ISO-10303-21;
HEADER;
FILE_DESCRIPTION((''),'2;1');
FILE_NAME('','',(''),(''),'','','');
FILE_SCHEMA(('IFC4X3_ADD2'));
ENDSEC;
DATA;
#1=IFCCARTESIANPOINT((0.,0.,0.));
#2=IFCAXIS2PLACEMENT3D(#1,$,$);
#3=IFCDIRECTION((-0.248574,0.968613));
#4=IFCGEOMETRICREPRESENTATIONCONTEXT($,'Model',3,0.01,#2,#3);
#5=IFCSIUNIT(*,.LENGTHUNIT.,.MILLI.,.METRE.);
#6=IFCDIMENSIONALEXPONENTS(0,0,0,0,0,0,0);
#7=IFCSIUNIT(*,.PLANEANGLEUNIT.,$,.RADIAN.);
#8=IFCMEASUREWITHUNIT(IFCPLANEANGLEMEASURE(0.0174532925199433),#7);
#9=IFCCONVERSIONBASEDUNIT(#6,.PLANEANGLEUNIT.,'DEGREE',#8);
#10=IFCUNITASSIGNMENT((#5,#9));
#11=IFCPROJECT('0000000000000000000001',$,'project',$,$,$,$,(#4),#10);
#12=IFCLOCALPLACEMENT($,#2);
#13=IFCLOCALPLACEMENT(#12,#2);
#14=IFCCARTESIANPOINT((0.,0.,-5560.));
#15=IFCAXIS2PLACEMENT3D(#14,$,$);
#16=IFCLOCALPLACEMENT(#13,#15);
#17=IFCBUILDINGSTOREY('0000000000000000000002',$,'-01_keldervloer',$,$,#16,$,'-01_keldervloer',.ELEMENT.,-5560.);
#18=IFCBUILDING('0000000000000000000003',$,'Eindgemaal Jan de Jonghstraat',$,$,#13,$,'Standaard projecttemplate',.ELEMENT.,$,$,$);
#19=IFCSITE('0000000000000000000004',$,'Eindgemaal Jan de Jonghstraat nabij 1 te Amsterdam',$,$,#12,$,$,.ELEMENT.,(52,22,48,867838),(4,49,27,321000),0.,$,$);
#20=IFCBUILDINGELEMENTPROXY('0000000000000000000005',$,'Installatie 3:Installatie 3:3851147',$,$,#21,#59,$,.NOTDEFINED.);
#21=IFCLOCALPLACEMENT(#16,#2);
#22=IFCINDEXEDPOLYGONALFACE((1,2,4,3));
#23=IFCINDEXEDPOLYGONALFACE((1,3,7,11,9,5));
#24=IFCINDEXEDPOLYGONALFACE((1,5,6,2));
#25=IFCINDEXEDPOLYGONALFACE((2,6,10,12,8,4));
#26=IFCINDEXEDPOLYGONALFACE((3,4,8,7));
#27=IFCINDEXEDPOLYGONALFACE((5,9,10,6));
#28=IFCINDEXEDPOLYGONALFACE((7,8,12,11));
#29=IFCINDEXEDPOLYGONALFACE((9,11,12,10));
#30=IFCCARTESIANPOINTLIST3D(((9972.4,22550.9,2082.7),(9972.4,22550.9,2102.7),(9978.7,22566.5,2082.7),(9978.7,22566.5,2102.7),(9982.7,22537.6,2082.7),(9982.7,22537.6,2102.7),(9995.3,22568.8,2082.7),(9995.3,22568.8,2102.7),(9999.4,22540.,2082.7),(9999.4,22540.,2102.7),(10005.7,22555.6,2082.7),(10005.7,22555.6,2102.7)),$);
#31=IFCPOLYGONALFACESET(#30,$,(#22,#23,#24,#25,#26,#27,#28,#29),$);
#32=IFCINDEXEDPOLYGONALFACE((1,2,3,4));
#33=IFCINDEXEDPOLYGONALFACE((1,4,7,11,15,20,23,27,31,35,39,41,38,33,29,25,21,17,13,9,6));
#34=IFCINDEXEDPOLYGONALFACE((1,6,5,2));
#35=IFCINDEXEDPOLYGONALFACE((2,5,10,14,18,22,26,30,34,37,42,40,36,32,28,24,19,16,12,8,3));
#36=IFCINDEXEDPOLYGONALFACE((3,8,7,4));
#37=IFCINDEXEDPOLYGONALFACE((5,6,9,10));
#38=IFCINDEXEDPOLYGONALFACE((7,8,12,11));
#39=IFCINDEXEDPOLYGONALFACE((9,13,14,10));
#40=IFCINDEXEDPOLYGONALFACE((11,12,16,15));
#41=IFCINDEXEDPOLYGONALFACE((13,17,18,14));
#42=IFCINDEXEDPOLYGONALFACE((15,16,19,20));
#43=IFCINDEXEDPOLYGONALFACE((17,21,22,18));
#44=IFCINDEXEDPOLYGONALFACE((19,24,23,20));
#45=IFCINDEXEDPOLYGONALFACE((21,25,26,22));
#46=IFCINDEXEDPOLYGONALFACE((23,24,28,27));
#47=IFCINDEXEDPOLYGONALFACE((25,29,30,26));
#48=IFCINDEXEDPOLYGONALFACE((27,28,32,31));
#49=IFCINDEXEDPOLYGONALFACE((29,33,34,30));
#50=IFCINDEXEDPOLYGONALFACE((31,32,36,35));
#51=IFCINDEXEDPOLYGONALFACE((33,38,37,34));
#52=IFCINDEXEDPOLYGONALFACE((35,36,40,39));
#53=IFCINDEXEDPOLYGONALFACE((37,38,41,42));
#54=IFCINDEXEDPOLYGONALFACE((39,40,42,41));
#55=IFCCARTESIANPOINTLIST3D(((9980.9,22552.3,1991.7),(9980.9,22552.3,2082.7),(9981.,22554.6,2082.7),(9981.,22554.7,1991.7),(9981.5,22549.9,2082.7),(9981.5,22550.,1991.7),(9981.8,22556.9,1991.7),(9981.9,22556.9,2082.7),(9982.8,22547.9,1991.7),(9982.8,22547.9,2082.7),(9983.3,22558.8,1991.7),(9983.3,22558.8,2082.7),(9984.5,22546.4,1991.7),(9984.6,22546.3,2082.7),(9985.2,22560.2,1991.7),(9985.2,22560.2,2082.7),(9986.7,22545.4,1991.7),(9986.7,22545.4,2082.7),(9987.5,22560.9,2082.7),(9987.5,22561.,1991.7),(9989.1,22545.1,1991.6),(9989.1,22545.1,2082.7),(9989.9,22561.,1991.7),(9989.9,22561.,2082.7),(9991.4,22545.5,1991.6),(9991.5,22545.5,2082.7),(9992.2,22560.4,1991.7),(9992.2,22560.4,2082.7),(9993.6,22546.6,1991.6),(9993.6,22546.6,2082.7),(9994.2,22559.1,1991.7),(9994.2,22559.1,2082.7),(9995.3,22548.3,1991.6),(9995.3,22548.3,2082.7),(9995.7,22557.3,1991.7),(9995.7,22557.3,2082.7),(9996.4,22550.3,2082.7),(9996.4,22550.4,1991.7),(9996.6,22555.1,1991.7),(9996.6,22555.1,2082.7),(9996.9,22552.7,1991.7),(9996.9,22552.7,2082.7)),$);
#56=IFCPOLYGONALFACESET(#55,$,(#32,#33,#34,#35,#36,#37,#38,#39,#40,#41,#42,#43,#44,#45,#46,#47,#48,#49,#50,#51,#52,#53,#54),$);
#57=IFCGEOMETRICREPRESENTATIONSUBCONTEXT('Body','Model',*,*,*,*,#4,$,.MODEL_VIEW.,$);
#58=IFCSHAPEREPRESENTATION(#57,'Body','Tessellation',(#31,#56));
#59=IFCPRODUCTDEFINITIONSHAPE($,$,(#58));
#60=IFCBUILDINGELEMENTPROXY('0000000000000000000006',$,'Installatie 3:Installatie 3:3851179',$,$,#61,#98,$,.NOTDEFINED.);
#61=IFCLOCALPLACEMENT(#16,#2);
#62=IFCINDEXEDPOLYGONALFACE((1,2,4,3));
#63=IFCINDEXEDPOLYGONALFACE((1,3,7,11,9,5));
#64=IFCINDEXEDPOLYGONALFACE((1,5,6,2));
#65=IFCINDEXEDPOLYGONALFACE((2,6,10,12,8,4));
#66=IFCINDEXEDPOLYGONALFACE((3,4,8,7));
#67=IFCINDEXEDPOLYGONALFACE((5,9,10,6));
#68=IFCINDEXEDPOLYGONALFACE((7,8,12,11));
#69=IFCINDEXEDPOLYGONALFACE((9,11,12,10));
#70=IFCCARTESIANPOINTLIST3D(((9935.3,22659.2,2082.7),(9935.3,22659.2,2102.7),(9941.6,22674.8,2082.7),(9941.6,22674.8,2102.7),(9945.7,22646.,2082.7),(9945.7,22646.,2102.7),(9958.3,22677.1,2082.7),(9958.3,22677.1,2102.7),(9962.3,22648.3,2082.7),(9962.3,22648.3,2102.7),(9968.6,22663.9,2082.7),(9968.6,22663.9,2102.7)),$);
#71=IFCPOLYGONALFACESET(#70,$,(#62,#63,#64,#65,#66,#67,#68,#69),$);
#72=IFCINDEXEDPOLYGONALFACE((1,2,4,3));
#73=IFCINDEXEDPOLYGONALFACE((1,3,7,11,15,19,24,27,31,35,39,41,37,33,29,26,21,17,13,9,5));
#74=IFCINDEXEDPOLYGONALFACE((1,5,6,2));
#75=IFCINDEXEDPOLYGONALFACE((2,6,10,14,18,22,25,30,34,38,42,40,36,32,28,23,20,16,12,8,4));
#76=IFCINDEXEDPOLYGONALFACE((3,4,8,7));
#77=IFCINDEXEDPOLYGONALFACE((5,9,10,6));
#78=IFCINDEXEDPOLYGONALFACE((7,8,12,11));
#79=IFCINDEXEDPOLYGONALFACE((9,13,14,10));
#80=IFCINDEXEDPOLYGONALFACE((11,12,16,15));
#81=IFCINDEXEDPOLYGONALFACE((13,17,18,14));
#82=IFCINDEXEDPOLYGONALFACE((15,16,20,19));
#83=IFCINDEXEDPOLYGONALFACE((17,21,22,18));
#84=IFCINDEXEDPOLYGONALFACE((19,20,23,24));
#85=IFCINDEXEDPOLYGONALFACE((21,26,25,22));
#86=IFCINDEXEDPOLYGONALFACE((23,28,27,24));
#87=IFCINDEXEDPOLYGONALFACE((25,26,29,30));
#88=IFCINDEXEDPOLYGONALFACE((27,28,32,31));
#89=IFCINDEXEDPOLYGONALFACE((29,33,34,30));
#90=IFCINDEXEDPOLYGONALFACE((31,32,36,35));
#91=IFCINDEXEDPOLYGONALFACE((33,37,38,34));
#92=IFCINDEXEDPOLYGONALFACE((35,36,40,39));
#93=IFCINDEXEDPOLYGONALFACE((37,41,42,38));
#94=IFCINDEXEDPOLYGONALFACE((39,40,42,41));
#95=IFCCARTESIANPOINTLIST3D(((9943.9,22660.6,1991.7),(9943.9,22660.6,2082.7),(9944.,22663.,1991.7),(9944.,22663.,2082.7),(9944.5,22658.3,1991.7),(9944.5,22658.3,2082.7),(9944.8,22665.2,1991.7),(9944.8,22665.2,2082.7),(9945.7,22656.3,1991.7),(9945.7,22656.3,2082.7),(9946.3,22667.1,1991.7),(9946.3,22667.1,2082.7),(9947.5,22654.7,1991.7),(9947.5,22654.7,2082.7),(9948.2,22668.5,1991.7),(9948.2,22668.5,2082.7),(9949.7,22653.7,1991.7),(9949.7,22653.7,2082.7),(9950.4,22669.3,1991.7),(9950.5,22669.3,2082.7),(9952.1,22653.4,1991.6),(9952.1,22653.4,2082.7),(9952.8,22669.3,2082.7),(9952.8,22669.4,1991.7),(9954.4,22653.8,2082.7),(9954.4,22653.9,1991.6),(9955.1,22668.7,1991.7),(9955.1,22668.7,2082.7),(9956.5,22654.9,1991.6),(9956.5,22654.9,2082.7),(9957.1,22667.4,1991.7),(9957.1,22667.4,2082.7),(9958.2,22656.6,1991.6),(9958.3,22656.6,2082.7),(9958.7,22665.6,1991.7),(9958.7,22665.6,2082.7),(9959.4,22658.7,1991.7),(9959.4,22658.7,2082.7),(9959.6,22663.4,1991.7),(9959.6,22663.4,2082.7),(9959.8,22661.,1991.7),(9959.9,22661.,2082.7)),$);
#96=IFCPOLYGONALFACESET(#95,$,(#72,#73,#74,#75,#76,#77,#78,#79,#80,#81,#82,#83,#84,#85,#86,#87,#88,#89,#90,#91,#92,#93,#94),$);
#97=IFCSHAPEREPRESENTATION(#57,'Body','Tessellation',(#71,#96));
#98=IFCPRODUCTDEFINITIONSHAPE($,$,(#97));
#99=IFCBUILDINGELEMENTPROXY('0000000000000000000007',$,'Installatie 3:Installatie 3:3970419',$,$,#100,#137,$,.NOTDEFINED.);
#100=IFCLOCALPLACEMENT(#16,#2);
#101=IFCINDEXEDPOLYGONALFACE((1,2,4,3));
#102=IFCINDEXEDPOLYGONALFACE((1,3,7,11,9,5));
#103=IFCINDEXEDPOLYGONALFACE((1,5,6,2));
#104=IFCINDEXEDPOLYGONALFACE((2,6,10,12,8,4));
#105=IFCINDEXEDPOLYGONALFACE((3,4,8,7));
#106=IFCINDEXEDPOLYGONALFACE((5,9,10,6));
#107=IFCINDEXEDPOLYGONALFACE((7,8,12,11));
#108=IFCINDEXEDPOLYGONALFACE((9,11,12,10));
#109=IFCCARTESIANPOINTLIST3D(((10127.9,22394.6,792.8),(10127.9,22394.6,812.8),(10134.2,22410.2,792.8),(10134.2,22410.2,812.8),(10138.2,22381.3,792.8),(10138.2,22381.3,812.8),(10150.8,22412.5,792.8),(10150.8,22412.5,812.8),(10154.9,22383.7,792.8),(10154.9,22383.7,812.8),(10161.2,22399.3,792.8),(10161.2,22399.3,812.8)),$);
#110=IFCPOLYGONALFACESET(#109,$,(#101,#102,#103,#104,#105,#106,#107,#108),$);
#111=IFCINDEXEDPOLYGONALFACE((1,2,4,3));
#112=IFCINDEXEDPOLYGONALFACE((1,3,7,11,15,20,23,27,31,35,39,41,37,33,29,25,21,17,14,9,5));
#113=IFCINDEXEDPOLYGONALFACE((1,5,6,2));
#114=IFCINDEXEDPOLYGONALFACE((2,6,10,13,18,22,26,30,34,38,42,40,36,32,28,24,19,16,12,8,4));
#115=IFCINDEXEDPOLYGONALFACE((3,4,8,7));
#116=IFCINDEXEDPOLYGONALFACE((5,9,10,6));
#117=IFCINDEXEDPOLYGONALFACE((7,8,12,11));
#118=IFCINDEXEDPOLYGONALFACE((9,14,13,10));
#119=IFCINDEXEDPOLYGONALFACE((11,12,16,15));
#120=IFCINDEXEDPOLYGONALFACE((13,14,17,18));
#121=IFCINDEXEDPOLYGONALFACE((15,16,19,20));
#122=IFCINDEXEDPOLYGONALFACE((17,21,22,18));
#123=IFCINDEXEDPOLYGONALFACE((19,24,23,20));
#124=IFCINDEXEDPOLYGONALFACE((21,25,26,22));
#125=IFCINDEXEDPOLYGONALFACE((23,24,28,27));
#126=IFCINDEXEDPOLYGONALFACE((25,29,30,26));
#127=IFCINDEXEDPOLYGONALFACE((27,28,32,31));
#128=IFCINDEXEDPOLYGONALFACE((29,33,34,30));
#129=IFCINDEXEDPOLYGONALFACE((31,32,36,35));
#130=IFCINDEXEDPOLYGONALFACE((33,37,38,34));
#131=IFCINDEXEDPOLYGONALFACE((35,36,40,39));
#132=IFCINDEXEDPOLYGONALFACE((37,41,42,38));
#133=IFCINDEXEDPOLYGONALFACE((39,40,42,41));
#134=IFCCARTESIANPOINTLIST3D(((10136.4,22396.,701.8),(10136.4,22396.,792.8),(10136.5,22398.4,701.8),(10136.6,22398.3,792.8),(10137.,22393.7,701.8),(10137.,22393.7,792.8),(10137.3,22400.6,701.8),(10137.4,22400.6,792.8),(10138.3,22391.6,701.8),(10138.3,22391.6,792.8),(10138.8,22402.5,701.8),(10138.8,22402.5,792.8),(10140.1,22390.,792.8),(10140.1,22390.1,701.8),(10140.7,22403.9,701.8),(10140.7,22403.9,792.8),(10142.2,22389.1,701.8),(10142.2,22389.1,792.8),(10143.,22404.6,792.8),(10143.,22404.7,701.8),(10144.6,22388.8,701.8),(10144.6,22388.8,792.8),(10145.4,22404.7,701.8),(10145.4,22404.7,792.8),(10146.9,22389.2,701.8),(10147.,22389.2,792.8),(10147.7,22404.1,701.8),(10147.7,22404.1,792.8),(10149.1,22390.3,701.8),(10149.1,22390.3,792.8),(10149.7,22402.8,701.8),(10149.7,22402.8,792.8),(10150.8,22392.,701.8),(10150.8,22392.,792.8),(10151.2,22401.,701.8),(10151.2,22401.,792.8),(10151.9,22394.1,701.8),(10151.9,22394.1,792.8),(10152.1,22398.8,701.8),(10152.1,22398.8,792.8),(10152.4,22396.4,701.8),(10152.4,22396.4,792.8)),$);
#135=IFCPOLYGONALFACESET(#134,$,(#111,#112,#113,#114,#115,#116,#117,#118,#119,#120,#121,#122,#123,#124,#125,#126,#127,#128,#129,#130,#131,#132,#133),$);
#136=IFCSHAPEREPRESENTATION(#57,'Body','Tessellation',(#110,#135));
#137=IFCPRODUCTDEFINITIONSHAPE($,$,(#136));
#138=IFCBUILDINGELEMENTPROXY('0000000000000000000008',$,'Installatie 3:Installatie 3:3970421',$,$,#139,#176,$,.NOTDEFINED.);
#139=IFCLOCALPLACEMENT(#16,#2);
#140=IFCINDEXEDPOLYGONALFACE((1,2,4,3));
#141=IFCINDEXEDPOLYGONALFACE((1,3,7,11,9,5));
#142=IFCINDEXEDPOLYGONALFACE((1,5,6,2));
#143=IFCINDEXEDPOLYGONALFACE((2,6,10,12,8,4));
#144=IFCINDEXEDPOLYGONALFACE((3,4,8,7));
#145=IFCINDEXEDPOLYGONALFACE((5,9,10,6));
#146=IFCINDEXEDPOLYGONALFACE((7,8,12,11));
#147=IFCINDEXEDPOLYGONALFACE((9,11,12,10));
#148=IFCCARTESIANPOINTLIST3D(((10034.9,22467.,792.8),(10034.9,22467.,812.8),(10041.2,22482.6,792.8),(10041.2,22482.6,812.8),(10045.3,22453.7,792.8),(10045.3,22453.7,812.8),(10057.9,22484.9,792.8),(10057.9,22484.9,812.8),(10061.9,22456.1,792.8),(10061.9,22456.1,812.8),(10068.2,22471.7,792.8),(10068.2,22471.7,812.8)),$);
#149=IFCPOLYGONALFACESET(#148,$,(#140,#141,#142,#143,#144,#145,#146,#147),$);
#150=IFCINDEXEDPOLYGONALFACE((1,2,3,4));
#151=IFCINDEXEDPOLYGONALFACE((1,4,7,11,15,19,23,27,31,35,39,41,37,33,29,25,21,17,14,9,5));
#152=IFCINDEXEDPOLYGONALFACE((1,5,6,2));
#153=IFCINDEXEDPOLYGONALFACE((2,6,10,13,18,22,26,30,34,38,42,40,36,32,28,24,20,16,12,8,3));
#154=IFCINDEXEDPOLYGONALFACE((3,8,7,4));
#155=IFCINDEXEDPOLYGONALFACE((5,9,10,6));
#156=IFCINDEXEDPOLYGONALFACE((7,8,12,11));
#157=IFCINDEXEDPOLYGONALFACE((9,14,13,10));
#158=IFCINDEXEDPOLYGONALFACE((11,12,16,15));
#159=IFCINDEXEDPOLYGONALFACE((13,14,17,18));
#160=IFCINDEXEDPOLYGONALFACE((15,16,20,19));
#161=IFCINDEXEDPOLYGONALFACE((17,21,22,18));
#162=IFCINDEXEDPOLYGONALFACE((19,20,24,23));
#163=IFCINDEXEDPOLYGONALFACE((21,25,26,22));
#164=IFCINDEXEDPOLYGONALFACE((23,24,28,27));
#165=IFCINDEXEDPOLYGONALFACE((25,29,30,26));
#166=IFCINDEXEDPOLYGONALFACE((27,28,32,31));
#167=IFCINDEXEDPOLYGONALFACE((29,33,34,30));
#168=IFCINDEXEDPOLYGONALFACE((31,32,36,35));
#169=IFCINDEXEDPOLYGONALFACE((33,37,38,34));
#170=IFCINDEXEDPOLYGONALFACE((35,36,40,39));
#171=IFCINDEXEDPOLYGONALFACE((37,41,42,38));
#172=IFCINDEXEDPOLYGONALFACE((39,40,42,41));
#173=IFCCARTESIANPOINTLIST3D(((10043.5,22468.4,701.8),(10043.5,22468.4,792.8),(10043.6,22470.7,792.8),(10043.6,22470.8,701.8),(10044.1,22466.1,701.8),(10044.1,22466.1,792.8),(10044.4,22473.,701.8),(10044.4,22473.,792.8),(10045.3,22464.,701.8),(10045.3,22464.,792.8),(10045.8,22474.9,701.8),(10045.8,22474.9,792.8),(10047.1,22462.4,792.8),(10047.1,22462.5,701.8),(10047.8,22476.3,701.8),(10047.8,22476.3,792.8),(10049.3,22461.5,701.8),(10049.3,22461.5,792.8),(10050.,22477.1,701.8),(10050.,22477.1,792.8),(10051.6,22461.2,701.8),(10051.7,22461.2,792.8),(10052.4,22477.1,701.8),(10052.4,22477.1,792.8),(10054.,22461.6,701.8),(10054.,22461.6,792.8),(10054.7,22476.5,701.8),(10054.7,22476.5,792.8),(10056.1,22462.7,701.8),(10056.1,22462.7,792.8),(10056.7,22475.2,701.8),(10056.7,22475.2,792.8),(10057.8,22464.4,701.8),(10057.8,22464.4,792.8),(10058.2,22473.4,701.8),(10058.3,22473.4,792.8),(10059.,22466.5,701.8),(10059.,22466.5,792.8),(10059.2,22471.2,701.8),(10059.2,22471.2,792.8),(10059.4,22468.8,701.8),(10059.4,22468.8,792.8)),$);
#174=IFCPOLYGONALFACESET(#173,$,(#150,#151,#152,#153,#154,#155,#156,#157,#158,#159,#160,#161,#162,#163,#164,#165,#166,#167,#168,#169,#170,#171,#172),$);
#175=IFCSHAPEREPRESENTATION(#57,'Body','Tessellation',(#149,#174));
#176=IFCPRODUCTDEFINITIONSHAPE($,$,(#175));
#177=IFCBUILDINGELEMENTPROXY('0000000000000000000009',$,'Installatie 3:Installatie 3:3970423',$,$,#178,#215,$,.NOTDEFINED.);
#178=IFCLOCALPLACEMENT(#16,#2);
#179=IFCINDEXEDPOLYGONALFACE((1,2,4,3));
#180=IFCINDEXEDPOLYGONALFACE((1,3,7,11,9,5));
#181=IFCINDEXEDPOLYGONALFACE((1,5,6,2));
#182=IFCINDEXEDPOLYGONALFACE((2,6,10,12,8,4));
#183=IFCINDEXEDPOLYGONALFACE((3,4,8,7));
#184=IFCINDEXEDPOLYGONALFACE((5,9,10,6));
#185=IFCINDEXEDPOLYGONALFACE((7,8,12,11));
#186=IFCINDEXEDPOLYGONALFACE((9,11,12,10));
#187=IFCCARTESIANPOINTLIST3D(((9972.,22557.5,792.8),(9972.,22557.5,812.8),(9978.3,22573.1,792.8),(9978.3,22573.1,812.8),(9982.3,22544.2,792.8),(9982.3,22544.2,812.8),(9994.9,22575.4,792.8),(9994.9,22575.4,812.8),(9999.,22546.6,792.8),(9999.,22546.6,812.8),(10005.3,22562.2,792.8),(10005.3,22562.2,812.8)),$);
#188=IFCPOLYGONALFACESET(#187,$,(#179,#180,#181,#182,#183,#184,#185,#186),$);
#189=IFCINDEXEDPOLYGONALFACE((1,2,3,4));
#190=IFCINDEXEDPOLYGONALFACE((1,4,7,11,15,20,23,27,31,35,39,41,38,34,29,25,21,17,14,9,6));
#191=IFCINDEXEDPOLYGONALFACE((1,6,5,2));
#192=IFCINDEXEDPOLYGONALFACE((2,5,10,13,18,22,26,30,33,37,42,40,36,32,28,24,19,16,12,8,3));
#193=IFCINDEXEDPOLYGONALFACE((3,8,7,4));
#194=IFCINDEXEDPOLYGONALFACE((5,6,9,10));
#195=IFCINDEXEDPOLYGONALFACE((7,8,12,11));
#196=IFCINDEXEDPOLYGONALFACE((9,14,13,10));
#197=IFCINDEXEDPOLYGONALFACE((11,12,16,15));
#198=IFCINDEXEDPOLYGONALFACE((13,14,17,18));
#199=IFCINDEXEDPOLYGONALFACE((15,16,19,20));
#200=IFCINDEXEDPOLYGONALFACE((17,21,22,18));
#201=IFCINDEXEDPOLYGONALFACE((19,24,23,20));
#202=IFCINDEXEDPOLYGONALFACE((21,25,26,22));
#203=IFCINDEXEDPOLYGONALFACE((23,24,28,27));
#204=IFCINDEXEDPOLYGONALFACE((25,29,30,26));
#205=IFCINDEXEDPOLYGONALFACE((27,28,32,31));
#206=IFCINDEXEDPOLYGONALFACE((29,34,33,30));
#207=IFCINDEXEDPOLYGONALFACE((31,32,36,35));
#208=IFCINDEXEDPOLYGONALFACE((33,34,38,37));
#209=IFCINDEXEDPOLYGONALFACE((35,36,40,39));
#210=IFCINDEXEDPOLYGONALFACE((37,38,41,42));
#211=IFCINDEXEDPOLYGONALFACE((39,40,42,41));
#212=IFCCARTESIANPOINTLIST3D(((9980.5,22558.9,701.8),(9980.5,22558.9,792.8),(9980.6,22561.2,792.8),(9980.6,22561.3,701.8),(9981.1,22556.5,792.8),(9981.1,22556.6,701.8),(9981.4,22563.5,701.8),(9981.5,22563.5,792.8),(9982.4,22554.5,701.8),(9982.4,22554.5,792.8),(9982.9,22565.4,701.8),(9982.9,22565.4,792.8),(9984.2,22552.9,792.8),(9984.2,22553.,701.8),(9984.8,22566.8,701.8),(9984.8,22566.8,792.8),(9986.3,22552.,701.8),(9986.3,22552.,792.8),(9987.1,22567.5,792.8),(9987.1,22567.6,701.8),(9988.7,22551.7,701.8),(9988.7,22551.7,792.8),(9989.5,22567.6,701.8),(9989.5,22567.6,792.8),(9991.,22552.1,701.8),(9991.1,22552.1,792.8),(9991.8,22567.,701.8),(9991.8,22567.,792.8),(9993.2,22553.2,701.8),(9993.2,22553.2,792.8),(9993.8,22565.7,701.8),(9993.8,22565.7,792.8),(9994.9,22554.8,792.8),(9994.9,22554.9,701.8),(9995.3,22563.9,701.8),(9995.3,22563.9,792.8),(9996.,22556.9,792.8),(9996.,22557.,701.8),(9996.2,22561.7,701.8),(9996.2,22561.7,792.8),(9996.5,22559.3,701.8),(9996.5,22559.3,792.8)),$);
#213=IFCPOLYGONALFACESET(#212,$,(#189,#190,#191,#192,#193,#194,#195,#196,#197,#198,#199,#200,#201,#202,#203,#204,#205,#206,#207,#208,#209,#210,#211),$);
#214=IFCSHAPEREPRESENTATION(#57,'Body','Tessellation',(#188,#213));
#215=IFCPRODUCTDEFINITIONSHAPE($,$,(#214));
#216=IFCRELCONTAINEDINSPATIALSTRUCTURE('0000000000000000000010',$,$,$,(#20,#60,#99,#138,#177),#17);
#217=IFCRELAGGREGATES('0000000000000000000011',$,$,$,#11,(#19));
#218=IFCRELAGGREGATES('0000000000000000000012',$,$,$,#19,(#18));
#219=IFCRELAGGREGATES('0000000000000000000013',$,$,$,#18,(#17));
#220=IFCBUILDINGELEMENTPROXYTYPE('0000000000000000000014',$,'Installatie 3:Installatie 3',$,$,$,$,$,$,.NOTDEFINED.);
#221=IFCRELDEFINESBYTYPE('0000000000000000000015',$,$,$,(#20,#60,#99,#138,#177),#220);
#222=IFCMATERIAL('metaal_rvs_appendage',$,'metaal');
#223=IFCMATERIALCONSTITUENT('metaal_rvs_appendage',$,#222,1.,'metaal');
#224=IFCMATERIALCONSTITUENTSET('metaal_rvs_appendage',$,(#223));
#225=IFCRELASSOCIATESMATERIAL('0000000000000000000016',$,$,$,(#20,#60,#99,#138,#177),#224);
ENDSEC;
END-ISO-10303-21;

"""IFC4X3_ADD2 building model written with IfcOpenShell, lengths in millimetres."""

from ifc_helpers import new_model, entity, si_unit, converted_unit, direction, frame, frame_2d, origin, place, context, subcontext, project, spatial, polyline, circle, outline, extrude, source, transform, mapped, material, constituent, constituent_set, type_object, type_shapes, element, save


model = new_model("IFC4X3_ADD2")

# Units and contexts
model_context = context("Model", 3, precision=0.01, world=origin(), true_north=direction((-0.248574, 0.968613)))
body_context = subcontext(model_context, "Body", "Model", "MODEL_VIEW")
ifc_project = project(units=[si_unit("LENGTHUNIT", "METRE", prefix="MILLI"), converted_unit("PLANEANGLEUNIT", "DEGREE", entity("IfcPlaneAngleMeasure", 0.0174532925199433), si_unit("PLANEANGLEUNIT", "RADIAN"), dimensions=[0, 0, 0, 0, 0, 0, 0])], contexts=[model_context])

# Site, building, storey
site_placement = place(None, origin())
site = spatial("IfcSite", under=ifc_project, at=site_placement, Name="Eindgemaal Jan de Jonghstraat nabij 1 te Amsterdam", CompositionType="ELEMENT", RefLatitude=(52, 22, 48, 867838), RefLongitude=(4, 49, 27, 321000), RefElevation=0.0)
building_placement = place(site_placement, origin())
building = spatial("IfcBuilding", under=site, at=building_placement, Name="Eindgemaal Jan de Jonghstraat", LongName="Standaard projecttemplate", CompositionType="ELEMENT")
storey_placement = place(building_placement, frame((0.0, 0.0, -5560.0)))
storey = spatial("IfcBuildingStorey", under=building, at=storey_placement, Name="-01_keldervloer", LongName="-01_keldervloer", CompositionType="ELEMENT", Elevation=-5560.0)

# Building element proxies
ifc_material_1 = material(Name="metaal_rvs_appendage", Category="metaal")
ifc_constituent_1 = constituent(ifc_material_1, Name="metaal_rvs_appendage", Category="metaal", fraction=1.0)
ifc_constituent_set_1 = constituent_set(constituents=[ifc_constituent_1], Name="metaal_rvs_appendage")
building_element_proxy_type_1 = type_object("IfcBuildingElementProxyType", Name="Installatie 3:Installatie 3", PredefinedType="NOTDEFINED")
shared_shape_1 = source(origin(), body_context, "Body", "SweptSolid", [
    extrude(outline(polyline([(-8.4, -14.6), (8.4, -14.6), (16.8, 0.0), (8.4, 14.6), (-8.4, 14.6), (-16.8, 0.0), (-8.4, -14.6)])), frame((0.0, 0.0, 41.5), z_axis=(0.0, 0.0, 1.0), x_axis=(-0.400458, 0.916315, 0.0)), (0.0, 0.0, 1.0), 20.0),
    extrude(circle(Radius=8.0, at=frame_2d((0.0, 0.0), x_axis=(1.0, 0.0))), frame((-0.2, -0.1, -49.5), z_axis=(0.000101, -0.000286, 1.0), x_axis=(1.0, 0.0, -0.000101)), (0.0, 0.0, 1.0), 91.1),
])
type_shapes(building_element_proxy_type_1, [shared_shape_1])
for number, where, z_axis, x_axis, name in (
    (1, (9989.0, 22553.2, 2041.2), (0.0, 0.0, 1.0), (0.968613, 0.248574, 0.0), "Installatie 3:Installatie 3:3851147"),
    (2, (9952.0, 22661.6, 2041.2), (0.0, 0.0, 1.0), (0.968613, 0.248574, 0.0), "Installatie 3:Installatie 3:3851179"),
    (3, (10144.5, 22396.9, 751.3), (0.0, 0.0, 1.0), (0.968613, 0.248574, 0.0), "Installatie 3:Installatie 3:3970419"),
    (4, (10051.6, 22469.3, 751.3), (0.0, 0.0, 1.0), (0.968613, 0.248574, 0.0), "Installatie 3:Installatie 3:3970421"),
    (5, (9988.6, 22559.8, 751.3), (0.0, 0.0, 1.0), (0.968613, 0.248574, 0.0), "Installatie 3:Installatie 3:3970423"),
):
    element("IfcBuildingElementProxy", number, at=place(storey_placement, frame(where, z_axis=z_axis, x_axis=x_axis)), inside=storey, type_object=building_element_proxy_type_1, material=ifc_constituent_set_1, Name=name, PredefinedType="NOTDEFINED", context=body_context, shape_type="MappedRepresentation", body=[
        mapped(shared_shape_1, transform((0.0, 0.0, 0.0), scale=1.0)),
    ])

save(model, "model.ifc")
